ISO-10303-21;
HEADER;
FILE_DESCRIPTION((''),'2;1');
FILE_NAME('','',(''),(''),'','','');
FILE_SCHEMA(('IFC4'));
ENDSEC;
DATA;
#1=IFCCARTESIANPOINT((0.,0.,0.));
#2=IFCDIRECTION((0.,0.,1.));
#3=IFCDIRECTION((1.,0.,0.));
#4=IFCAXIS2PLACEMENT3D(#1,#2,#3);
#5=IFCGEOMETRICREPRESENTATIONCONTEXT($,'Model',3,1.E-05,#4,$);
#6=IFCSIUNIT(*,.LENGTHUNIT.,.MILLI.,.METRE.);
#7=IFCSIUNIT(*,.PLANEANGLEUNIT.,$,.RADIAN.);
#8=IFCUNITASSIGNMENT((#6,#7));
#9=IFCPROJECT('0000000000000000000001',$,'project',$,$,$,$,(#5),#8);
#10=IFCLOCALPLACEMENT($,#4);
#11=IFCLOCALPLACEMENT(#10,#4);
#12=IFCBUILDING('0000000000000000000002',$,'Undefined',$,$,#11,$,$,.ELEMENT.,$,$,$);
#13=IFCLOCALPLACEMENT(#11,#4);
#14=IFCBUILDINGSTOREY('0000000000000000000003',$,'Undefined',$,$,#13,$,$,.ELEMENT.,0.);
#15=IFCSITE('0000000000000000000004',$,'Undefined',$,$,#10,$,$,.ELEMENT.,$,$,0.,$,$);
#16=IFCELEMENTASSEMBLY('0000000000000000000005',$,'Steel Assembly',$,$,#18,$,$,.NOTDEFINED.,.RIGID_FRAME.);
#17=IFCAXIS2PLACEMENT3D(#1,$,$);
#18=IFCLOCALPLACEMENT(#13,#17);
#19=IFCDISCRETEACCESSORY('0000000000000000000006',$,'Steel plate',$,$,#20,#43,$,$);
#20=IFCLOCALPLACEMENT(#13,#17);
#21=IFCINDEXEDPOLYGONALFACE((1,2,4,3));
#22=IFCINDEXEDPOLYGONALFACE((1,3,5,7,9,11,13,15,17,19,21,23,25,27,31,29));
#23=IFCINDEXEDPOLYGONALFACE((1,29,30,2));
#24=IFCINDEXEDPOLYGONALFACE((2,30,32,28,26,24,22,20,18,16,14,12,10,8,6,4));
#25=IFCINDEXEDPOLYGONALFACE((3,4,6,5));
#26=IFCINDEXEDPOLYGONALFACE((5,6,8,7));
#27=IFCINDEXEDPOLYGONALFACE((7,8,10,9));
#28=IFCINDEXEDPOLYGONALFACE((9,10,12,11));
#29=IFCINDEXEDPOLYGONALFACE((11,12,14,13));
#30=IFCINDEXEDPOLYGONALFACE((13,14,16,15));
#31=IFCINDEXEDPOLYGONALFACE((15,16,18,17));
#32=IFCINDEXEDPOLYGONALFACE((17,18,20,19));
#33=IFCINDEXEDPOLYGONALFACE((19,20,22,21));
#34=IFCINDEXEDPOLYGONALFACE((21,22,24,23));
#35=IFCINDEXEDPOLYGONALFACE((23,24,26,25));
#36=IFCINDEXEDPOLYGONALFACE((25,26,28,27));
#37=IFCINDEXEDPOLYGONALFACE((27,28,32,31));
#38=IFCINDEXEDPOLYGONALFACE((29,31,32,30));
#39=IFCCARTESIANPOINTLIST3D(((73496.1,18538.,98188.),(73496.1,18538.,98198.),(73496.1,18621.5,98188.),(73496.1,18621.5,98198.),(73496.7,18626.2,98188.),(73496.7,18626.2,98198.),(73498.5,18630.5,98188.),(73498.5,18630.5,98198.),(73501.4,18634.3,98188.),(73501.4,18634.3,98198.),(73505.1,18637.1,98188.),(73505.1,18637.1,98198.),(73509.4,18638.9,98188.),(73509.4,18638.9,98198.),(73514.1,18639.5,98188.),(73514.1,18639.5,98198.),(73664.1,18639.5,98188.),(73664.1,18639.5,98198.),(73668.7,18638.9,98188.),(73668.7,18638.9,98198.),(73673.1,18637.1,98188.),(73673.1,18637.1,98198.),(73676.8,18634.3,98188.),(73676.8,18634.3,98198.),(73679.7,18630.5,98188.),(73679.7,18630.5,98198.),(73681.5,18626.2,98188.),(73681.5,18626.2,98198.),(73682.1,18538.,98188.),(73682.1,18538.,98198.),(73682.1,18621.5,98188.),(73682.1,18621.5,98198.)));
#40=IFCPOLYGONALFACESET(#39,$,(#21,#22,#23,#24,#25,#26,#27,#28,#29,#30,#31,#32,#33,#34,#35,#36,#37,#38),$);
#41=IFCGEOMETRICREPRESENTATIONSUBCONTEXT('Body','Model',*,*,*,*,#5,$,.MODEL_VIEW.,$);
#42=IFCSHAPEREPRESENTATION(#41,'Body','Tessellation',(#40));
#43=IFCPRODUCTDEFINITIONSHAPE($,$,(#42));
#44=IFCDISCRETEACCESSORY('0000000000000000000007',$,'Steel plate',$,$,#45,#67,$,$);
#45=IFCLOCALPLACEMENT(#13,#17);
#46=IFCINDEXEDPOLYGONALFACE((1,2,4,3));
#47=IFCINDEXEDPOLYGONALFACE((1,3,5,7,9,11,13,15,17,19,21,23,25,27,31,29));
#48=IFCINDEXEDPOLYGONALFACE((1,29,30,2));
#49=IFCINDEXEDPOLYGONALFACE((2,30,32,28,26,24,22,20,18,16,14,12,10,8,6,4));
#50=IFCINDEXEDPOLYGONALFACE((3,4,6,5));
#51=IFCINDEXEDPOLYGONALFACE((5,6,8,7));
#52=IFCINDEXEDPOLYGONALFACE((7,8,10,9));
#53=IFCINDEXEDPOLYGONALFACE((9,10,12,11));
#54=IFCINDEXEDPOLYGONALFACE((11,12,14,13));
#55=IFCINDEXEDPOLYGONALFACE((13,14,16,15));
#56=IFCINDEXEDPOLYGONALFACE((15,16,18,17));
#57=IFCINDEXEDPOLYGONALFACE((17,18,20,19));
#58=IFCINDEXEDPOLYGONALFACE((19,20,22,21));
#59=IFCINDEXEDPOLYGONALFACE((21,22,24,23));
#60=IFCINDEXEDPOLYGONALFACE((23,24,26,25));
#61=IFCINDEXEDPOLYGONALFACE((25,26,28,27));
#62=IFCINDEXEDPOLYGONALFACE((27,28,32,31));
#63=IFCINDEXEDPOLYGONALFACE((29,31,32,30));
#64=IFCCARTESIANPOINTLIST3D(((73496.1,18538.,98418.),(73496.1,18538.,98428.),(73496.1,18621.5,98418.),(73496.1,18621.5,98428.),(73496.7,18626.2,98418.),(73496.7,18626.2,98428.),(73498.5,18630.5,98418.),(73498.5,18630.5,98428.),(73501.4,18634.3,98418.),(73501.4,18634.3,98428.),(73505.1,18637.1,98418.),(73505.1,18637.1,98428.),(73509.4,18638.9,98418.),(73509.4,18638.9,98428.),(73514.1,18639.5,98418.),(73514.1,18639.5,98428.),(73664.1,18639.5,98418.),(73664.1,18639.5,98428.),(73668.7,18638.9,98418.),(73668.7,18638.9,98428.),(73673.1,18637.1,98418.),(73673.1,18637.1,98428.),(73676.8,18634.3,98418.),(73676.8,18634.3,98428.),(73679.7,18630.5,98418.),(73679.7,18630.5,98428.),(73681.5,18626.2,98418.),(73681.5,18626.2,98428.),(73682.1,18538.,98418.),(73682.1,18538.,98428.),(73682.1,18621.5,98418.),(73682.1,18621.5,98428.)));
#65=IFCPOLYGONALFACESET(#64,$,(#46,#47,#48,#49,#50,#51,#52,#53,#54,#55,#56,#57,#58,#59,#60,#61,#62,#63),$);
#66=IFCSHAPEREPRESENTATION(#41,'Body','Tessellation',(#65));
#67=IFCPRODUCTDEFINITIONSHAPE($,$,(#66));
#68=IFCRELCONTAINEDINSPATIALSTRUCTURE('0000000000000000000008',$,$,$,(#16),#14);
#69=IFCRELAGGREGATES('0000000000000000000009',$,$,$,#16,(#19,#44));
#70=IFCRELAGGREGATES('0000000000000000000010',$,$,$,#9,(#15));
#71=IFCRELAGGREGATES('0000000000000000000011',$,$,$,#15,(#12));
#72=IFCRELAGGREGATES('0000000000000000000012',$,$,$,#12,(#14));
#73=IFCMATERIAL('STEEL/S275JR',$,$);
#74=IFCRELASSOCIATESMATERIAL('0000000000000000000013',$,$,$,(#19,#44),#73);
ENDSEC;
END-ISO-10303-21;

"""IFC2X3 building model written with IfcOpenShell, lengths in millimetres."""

from ifc_helpers import new_model, si_unit, frame, frame_2d, origin_with_axes, place, context, subcontext, project, spatial, polyline, circle_curve, parameter, trimmed, segment, composite_curve, outline, extrude, material, element, aggregate, save


model = new_model("IFC2X3")

# Units and contexts
model_context = context("Model", 3, precision=1e-05, world=origin_with_axes())
body_context = subcontext(model_context, "Body", "Model", "MODEL_VIEW")
ifc_project = project(units=[si_unit("LENGTHUNIT", "METRE", prefix="MILLI"), si_unit("PLANEANGLEUNIT", "RADIAN")], contexts=[model_context])

# Site, building, storey
site_placement = place(None, origin_with_axes())
site = spatial("IfcSite", under=ifc_project, at=site_placement, Name="Undefined", CompositionType="ELEMENT", RefElevation=0.0)
building_placement = place(site_placement, origin_with_axes())
building = spatial("IfcBuilding", under=site, at=building_placement, Name="Undefined", CompositionType="ELEMENT")
storey_placement = place(building_placement, origin_with_axes())
storey = spatial("IfcBuildingStorey", under=building, at=storey_placement, Name="Undefined", CompositionType="ELEMENT", Elevation=0.0)

# Element assembly
assembly_1_placement = place(storey_placement, origin_with_axes())
assembly_1 = element("IfcElementAssembly", 1, at=assembly_1_placement, inside=storey, Name="Steel Assembly", AssemblyPlace="NOTDEFINED", PredefinedType="RIGID_FRAME")

# Shared definitions
ifc_material_1 = material(Name="STEEL/S275JR")

# Discrete accessories
discrete_accessory_1_placement = place(assembly_1_placement, frame((73496.1, 18538.0, 98193.0), z_axis=(0.0, 0.0, 1.0), x_axis=(1.0, 0.0, 0.0)))
discrete_accessory_1 = element("IfcDiscreteAccessory", 2, at=discrete_accessory_1_placement, material=ifc_material_1, Name="Steel plate", context=body_context, shape_type="SweptSolid", body=[
    extrude(outline(composite_curve([segment(polyline([(0.0, 0.0), (186.0, 0.0), (186.0, 83.5)]), True, "CONTINUOUS"), segment(trimmed(circle_curve(frame_2d((168.0, 83.5), x_axis=(1.0, 0.0)), 18.0), [parameter(0.0)], [parameter(1.570796)], True, "PARAMETER"), True, "CONTINUOUS"), segment(polyline([(168.0, 101.5), (18.0, 101.5)]), True, "CONTINUOUS"), segment(trimmed(circle_curve(frame_2d((18.0, 83.5), x_axis=(0.0, 1.0)), 18.0), [parameter(0.0)], [parameter(1.570796)], True, "PARAMETER"), True, "CONTINUOUS"), segment(polyline([(0.0, 83.5), (0.0, 0.0)]), True, "DISCONTINUOUS")], self_intersect=False)), frame((0.0, 0.0, -5.0), z_axis=(0.0, 0.0, 1.0), x_axis=(1.0, 0.0, 0.0)), (0.0, 0.0, 1.0), 10.0),
])
discrete_accessory_2_placement = place(assembly_1_placement, frame((73496.1, 18538.0, 98423.0), z_axis=(0.0, 0.0, 1.0), x_axis=(1.0, 0.0, 0.0)))
discrete_accessory_2 = element("IfcDiscreteAccessory", 3, at=discrete_accessory_2_placement, material=ifc_material_1, Name="Steel plate", context=body_context, shape_type="SweptSolid", body=[
    extrude(outline(composite_curve([segment(polyline([(0.0, 0.0), (186.0, 0.0), (186.0, 83.5)]), True, "CONTINUOUS"), segment(trimmed(circle_curve(frame_2d((168.0, 83.5), x_axis=(1.0, 0.0)), 18.0), [parameter(0.0)], [parameter(1.570796)], True, "PARAMETER"), True, "CONTINUOUS"), segment(polyline([(168.0, 101.5), (18.0, 101.5)]), True, "CONTINUOUS"), segment(trimmed(circle_curve(frame_2d((18.0, 83.5), x_axis=(0.0, 1.0)), 18.0), [parameter(0.0)], [parameter(1.570796)], True, "PARAMETER"), True, "CONTINUOUS"), segment(polyline([(0.0, 83.5), (0.0, 0.0)]), True, "DISCONTINUOUS")], self_intersect=False)), frame((0.0, 0.0, -5.0), z_axis=(0.0, 0.0, 1.0), x_axis=(1.0, 0.0, 0.0)), (0.0, 0.0, 1.0), 10.0),
])
aggregate(assembly_1, [discrete_accessory_1, discrete_accessory_2])

save(model, "model.ifc")
